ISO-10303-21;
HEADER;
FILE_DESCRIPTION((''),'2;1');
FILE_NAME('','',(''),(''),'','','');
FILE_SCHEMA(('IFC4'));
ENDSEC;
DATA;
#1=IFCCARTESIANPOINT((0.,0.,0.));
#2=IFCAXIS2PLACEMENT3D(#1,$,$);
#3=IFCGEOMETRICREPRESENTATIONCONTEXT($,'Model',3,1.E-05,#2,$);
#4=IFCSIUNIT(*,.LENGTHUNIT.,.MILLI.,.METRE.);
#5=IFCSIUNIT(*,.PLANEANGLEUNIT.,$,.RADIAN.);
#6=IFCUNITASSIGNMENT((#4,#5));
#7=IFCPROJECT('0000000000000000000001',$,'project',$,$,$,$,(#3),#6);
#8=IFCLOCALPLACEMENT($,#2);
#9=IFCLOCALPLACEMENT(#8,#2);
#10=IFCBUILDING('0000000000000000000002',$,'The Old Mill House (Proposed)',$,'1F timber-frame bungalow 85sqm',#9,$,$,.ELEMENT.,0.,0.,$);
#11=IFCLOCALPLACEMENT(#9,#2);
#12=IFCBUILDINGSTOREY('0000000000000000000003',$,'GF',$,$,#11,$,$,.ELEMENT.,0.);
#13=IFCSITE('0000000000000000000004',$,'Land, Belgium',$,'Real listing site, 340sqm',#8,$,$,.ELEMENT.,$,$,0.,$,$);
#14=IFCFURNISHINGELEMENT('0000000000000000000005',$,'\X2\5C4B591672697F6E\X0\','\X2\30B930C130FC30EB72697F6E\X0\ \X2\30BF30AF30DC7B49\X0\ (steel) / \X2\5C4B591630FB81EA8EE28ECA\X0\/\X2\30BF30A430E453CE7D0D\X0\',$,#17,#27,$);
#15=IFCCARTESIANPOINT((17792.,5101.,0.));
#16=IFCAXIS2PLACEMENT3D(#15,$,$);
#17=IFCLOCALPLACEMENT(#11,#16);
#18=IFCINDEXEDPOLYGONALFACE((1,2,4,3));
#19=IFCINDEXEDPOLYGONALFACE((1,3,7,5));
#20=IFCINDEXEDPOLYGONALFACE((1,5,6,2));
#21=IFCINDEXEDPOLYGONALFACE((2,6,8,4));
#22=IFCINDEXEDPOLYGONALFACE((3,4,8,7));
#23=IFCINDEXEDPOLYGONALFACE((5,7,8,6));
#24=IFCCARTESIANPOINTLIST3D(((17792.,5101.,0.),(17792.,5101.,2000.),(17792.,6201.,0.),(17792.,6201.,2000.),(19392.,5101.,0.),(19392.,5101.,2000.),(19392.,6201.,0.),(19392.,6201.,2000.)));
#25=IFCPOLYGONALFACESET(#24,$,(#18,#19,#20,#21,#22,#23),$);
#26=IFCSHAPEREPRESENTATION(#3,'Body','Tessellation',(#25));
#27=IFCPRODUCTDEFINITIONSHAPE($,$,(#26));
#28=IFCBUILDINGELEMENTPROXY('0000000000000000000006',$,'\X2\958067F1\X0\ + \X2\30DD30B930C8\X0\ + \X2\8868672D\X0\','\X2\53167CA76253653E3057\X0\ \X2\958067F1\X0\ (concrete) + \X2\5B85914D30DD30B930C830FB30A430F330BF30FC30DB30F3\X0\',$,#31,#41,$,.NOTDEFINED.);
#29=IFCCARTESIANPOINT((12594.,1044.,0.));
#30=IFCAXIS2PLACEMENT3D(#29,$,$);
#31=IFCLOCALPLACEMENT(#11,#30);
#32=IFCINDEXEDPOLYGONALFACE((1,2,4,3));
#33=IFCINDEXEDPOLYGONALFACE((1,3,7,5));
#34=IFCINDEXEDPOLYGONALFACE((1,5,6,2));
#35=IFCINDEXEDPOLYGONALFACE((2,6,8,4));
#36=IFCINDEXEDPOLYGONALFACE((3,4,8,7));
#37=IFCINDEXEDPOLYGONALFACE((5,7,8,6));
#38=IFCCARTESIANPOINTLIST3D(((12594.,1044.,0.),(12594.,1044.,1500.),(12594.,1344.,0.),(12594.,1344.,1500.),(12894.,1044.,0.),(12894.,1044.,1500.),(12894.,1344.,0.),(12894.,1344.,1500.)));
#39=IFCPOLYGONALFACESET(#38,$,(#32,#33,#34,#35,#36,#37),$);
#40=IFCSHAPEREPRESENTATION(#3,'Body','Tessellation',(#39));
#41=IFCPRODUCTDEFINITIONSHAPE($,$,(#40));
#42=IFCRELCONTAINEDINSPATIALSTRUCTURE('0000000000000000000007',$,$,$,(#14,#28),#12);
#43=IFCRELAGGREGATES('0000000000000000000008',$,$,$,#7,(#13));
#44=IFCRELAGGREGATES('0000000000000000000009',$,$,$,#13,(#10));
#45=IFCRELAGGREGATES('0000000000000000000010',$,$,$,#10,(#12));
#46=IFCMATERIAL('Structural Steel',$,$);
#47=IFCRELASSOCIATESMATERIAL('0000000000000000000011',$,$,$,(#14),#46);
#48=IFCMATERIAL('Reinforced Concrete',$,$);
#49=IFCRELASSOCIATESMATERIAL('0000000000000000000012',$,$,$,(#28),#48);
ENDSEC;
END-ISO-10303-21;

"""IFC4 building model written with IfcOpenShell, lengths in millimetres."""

from ifc_helpers import new_model, si_unit, frame, frame_2d, origin, place, context, project, spatial, rectangle, extrude, material, element, save


model = new_model("IFC4")

# Units and contexts
model_context = context("Model", 3, precision=1e-05, world=origin())
ifc_project = project(units=[si_unit("LENGTHUNIT", "METRE", prefix="MILLI"), si_unit("PLANEANGLEUNIT", "RADIAN")], contexts=[model_context])

# Site, building, storey
site_placement = place(None, origin())
site = spatial("IfcSite", under=ifc_project, at=site_placement, Name="Land, Belgium", ObjectType="Real listing site, 340sqm", CompositionType="ELEMENT", RefElevation=0.0)
building_placement = place(site_placement, origin())
building = spatial("IfcBuilding", under=site, at=building_placement, Name="The Old Mill House (Proposed)", ObjectType="1F timber-frame bungalow 85sqm", CompositionType="ELEMENT", ElevationOfRefHeight=0.0, ElevationOfTerrain=0.0)
storey_placement = place(building_placement, origin())
storey = spatial("IfcBuildingStorey", under=building, at=storey_placement, Name="GF", CompositionType="ELEMENT", Elevation=0.0)

# Shared definitions
ifc_material_1 = material(Name="Structural Steel")

# Shared definitions
ifc_material_2 = material(Name="Reinforced Concrete")

# Furnishing element
furnishing_1_placement = place(storey_placement, frame((17792.0, 5101.0, 0.0)))
element("IfcFurnishingElement", 1, at=furnishing_1_placement, inside=storey, material=ifc_material_1, Name="屋外物置", Description="スチール物置 タクボ等 (steel) / 屋外・自転車/タイヤ収納", context=model_context, shape_type="SweptSolid", body=[
    extrude(rectangle(XDim=1600.0, YDim=1100.0, at=frame_2d((800.0, 550.0))), frame((17792.0, 5101.0, 0.0)), (0.0, 0.0, 1.0), 2000.0),
])

# Building element proxy
proxy_placement = place(storey_placement, frame((12594.0, 1044.0, 0.0)))
element("IfcBuildingElementProxy", 2, at=proxy_placement, inside=storey, material=ifc_material_2, Name="門柱 + ポスト + 表札", Description="化粧打放し 門柱 (concrete) + 宅配ポスト・インターホン", PredefinedType="NOTDEFINED", context=model_context, shape_type="SweptSolid", body=[
    extrude(rectangle(XDim=300.0, YDim=300.0, at=frame_2d((150.0, 150.0))), frame((12594.0, 1044.0, 0.0)), (0.0, 0.0, 1.0), 1500.0),
])

save(model, "model.ifc")
